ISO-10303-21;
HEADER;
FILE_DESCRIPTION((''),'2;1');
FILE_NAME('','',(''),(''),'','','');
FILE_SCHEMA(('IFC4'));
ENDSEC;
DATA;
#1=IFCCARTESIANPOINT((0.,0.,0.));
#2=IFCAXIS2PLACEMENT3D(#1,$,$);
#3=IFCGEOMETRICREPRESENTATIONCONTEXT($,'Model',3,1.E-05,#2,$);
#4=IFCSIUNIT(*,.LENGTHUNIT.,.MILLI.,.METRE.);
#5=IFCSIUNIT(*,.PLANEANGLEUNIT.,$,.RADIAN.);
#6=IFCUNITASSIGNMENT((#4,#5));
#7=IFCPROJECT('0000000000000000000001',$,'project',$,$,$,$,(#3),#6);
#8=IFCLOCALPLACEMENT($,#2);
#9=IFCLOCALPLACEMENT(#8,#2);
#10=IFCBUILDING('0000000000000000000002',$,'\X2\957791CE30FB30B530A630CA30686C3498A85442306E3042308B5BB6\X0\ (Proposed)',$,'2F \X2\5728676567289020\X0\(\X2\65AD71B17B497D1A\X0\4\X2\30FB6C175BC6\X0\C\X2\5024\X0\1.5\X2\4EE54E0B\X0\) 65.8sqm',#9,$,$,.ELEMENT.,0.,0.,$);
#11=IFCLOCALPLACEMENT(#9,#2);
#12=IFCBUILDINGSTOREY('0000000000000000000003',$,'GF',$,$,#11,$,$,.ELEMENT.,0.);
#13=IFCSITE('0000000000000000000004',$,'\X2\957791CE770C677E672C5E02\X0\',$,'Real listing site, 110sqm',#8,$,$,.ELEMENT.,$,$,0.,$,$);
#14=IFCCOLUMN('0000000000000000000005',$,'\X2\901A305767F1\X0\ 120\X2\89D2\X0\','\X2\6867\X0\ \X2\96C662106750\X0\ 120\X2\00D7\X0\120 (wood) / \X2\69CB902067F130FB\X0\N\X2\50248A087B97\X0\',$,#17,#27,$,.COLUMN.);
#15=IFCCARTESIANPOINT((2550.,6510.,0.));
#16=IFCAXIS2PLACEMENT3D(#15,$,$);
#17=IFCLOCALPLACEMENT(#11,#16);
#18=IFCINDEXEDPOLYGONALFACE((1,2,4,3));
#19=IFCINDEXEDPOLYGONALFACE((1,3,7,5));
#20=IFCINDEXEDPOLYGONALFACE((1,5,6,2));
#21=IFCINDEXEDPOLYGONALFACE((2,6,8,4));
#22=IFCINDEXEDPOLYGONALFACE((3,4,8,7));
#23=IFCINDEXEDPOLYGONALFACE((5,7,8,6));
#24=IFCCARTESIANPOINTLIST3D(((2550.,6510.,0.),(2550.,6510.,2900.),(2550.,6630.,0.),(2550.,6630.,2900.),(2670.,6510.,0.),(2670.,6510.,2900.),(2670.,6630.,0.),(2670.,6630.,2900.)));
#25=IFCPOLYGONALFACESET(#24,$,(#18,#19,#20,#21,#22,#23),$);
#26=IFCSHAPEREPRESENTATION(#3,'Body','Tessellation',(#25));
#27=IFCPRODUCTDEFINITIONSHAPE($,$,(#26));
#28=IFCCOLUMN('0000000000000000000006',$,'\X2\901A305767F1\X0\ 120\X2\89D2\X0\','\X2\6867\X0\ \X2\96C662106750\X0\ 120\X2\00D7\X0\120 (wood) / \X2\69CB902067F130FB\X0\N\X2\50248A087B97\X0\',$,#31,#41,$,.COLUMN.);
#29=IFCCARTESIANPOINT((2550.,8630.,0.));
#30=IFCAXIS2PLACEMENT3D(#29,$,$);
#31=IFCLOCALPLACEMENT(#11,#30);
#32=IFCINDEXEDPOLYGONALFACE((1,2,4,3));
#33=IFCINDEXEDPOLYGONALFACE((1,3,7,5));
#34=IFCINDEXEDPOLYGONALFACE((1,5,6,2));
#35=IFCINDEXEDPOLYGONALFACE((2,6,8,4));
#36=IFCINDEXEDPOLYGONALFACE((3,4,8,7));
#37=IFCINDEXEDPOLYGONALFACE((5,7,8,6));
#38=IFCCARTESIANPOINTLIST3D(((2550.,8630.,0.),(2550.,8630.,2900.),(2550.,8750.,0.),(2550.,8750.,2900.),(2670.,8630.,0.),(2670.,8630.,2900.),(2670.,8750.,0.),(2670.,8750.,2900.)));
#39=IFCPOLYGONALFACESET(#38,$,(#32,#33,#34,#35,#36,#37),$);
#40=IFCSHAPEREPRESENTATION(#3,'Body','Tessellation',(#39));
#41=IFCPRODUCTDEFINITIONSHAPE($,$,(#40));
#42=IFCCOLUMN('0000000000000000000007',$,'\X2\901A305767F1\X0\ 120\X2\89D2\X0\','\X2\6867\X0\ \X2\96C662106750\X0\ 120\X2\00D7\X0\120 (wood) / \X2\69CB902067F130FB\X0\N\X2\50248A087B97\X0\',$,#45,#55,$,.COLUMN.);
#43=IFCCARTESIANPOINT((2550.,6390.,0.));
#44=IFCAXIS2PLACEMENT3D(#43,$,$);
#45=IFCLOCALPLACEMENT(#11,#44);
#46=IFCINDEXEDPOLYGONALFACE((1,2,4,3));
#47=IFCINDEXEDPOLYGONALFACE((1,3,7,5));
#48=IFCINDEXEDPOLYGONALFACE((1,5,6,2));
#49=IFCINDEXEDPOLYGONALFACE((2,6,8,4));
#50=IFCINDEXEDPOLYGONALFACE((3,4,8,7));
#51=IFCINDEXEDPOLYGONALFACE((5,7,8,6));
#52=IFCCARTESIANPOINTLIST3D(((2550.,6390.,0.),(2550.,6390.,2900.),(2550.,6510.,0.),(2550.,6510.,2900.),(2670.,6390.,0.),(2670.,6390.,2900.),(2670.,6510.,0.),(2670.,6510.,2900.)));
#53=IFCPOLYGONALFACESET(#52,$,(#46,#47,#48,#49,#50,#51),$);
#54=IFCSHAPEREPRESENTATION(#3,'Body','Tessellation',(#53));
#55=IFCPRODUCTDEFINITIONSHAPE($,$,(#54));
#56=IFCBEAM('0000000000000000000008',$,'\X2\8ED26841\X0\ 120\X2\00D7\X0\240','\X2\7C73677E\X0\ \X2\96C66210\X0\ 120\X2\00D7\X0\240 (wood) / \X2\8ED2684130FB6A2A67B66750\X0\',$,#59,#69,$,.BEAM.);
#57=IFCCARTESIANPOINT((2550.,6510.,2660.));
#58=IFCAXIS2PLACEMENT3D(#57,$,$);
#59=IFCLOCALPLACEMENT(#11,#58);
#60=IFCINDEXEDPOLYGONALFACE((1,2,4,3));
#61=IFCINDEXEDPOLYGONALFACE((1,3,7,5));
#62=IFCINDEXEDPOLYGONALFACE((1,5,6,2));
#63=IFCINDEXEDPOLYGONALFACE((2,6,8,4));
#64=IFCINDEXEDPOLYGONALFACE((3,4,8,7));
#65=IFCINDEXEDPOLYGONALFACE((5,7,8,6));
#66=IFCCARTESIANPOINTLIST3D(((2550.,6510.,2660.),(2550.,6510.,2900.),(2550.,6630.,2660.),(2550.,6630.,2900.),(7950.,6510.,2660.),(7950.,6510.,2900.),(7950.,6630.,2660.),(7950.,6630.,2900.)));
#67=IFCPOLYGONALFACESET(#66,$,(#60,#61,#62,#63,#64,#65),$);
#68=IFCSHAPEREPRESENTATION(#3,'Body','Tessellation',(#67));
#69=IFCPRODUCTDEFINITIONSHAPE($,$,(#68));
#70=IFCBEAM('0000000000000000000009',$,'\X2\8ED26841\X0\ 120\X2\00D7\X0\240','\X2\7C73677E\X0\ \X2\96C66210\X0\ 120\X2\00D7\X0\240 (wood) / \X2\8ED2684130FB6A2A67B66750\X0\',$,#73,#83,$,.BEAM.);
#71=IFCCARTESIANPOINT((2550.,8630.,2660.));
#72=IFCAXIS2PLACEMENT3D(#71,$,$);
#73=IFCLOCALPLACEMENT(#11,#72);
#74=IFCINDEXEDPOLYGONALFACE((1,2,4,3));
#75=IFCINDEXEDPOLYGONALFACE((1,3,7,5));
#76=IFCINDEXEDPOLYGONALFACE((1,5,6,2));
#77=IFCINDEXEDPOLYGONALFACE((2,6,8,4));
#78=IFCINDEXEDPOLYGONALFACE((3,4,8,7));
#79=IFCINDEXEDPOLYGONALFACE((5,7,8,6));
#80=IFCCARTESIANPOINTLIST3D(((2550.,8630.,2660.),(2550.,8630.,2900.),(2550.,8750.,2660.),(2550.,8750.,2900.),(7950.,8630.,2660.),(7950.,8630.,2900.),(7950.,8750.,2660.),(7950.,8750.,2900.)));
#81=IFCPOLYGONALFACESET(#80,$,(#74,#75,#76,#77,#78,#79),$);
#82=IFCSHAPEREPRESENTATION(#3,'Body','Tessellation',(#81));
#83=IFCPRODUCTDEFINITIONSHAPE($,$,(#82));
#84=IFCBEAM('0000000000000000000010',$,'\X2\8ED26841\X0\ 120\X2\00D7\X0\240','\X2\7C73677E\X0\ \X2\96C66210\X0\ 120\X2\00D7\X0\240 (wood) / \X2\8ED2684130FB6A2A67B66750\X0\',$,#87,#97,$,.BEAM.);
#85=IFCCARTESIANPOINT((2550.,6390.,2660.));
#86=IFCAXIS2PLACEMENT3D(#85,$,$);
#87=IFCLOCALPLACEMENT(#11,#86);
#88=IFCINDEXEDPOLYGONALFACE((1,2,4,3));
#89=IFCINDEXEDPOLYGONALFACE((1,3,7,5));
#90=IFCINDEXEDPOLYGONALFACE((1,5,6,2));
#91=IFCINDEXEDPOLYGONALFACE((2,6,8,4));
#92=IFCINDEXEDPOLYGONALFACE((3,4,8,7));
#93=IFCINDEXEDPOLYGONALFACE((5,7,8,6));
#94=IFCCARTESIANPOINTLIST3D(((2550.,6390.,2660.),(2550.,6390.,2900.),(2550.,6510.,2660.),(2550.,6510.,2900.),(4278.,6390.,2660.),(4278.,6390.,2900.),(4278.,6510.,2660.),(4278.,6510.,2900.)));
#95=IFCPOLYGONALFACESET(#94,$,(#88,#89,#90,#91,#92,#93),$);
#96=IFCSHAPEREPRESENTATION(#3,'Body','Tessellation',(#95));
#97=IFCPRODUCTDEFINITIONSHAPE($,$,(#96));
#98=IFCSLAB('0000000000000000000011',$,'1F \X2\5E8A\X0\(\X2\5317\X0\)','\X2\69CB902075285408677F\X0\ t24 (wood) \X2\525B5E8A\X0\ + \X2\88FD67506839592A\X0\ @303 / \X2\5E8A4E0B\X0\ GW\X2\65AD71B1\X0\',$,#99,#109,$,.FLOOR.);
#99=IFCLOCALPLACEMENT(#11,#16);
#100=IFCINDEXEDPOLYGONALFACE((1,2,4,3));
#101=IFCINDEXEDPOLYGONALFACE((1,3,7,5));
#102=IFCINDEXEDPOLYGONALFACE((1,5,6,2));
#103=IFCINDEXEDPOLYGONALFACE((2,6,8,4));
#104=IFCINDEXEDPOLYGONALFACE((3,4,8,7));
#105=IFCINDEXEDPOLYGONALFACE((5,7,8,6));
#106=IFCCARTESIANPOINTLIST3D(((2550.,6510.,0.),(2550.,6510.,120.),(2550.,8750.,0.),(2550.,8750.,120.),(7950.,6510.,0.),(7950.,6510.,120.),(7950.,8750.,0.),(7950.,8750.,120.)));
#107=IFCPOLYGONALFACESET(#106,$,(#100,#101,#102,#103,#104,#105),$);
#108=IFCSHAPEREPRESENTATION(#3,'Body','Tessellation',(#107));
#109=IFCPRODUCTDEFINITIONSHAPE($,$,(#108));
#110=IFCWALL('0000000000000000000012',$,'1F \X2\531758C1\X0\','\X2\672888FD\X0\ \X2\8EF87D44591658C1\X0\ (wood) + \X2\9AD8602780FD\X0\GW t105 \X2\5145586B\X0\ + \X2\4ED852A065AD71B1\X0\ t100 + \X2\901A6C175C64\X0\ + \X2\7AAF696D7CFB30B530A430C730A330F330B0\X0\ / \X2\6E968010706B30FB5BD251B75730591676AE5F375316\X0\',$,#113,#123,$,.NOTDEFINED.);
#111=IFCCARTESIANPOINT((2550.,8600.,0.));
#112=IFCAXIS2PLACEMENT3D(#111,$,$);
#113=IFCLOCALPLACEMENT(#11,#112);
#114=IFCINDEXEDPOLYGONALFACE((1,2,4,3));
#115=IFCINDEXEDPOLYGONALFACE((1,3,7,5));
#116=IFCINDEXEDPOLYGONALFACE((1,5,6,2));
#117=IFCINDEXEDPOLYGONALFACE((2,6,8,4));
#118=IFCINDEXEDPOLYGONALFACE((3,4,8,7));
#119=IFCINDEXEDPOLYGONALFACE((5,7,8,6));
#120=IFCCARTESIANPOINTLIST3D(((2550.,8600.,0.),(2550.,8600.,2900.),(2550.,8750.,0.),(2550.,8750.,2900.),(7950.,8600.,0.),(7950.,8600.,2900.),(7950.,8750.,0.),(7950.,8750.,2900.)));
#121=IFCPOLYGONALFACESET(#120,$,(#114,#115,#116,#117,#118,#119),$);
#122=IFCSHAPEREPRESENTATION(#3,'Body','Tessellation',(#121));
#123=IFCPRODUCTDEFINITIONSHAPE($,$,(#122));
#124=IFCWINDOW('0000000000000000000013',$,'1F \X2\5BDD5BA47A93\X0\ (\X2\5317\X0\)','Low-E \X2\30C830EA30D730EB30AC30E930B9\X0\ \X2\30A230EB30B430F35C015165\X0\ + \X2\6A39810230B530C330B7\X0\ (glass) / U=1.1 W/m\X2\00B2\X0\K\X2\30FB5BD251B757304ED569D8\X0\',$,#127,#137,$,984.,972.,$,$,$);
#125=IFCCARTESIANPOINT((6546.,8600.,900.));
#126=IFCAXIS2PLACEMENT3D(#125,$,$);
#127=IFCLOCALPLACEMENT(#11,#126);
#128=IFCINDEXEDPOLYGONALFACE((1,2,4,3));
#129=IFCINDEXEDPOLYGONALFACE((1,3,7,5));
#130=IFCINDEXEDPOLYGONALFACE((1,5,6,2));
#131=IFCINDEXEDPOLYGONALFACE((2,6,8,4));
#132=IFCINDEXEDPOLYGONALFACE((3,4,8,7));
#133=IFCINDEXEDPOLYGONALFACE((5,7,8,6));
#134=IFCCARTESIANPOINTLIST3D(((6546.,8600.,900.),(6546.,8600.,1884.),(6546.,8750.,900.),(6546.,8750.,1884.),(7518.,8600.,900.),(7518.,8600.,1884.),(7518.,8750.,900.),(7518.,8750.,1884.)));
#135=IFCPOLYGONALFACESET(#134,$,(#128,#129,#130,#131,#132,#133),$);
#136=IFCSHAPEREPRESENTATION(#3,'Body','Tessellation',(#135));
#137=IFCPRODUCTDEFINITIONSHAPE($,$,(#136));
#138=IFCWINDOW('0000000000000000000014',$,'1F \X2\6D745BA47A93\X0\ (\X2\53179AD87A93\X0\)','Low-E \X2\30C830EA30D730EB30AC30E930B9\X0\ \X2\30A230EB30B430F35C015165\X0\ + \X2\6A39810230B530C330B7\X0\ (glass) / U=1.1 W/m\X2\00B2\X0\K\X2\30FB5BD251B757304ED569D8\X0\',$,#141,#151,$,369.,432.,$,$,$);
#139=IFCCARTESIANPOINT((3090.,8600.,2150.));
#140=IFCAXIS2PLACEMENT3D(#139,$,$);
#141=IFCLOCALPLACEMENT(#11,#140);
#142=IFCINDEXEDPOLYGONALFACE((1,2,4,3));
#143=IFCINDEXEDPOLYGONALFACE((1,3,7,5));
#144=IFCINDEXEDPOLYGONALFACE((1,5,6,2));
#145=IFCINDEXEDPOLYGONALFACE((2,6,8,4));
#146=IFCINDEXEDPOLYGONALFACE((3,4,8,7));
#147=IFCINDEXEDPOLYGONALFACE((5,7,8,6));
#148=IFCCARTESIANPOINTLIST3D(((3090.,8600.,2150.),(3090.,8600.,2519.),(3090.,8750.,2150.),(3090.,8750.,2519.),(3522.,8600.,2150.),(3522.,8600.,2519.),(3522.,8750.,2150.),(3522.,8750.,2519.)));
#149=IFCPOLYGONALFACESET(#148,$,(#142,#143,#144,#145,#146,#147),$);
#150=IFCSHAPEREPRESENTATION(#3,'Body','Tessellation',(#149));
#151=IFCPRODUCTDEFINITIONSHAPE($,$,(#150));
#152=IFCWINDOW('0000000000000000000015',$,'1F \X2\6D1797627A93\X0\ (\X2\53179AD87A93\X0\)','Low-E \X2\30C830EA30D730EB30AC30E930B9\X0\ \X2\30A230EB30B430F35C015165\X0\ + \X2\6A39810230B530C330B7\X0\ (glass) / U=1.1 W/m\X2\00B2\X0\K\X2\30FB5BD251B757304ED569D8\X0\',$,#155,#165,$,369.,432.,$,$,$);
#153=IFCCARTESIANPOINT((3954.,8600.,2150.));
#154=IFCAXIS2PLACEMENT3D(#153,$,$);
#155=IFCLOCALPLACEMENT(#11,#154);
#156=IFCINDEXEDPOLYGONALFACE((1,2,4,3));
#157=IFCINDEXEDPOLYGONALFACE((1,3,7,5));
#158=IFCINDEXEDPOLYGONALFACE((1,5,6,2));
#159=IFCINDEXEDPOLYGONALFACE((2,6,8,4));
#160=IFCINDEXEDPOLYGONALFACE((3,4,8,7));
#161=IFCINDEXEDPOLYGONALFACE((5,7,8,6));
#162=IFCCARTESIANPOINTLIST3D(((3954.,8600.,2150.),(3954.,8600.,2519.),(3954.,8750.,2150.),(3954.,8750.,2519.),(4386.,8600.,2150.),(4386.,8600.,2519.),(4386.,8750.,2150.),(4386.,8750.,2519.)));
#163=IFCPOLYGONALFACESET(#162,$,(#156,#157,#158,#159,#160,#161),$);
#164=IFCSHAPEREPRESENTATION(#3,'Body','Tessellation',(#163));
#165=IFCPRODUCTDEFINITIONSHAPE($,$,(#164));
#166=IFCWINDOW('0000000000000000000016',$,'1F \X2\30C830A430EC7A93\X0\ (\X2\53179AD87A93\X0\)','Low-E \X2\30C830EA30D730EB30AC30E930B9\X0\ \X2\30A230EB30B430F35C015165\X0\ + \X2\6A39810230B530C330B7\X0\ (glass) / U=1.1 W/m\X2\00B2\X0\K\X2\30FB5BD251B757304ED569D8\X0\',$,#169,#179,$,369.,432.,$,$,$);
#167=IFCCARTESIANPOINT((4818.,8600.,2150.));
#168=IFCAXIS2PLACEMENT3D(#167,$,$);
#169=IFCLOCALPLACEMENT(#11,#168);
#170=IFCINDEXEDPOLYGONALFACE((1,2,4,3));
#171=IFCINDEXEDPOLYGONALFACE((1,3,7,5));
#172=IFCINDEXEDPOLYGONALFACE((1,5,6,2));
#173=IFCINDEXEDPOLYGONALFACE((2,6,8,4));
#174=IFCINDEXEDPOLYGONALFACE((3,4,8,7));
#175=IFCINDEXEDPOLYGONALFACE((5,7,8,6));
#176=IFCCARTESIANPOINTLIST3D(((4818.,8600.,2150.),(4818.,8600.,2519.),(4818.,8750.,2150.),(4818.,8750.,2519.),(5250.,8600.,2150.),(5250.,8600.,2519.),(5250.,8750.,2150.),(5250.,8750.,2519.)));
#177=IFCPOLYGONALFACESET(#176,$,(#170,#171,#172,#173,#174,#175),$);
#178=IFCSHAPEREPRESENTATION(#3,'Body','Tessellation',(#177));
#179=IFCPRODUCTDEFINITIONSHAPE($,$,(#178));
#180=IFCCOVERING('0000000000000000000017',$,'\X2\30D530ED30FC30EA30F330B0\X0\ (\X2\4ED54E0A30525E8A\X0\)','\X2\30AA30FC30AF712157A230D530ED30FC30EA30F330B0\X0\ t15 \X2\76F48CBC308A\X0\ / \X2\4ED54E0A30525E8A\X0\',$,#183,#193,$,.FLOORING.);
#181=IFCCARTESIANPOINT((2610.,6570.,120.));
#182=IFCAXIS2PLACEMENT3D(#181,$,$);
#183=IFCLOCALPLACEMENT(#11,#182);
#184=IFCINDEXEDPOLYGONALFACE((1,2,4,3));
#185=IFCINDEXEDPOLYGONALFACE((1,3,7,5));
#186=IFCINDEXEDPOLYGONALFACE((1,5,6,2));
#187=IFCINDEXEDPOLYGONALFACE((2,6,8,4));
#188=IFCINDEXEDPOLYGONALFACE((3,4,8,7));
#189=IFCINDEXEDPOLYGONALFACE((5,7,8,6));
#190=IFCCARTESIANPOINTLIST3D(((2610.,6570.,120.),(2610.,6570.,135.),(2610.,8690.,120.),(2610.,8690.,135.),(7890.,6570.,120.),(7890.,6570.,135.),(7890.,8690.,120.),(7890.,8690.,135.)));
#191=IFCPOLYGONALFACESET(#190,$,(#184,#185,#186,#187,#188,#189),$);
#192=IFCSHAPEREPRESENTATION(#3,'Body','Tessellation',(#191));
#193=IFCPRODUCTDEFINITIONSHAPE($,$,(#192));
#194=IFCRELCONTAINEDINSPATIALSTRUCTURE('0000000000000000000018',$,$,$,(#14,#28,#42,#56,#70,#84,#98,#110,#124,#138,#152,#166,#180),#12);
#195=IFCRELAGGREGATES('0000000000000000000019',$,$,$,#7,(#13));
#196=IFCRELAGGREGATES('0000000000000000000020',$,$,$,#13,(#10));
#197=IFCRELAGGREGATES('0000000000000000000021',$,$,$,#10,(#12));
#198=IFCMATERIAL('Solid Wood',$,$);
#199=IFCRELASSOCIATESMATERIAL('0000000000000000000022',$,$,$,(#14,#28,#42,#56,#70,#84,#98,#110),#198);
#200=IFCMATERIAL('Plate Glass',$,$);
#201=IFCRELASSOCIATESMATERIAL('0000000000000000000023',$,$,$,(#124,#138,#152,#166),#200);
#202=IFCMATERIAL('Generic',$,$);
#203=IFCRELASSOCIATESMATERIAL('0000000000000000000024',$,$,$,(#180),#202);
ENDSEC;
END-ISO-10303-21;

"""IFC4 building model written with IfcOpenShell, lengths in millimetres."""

from ifc_helpers import new_model, si_unit, frame, frame_2d, origin, place, context, project, spatial, rectangle, extrude, material, element, fill, save


model = new_model("IFC4")

# Units and contexts
model_context = context("Model", 3, precision=1e-05, world=origin())
ifc_project = project(units=[si_unit("LENGTHUNIT", "METRE", prefix="MILLI"), si_unit("PLANEANGLEUNIT", "RADIAN")], contexts=[model_context])

# Site, building, storey
site_placement = place(None, origin())
site = spatial("IfcSite", under=ifc_project, at=site_placement, Name="長野県松本市", ObjectType="Real listing site, 110sqm", CompositionType="ELEMENT", RefElevation=0.0)
building_placement = place(site_placement, origin())
building = spatial("IfcBuilding", under=site, at=building_placement, Name="長野・サウナと水風呂のある家 (Proposed)", ObjectType="2F 在来木造(断熱等級4・気密C値1.5以下) 65.8sqm", CompositionType="ELEMENT", ElevationOfRefHeight=0.0, ElevationOfTerrain=0.0)
storey_placement = place(building_placement, origin())
storey = spatial("IfcBuildingStorey", under=building, at=storey_placement, Name="GF", CompositionType="ELEMENT", Elevation=0.0)

# Columns
ifc_material_1 = material(Name="Solid Wood")
column_1_placement = place(storey_placement, frame((2550.0, 6510.0, 0.0)))
element("IfcColumn", 1, at=column_1_placement, inside=storey, material=ifc_material_1, Name="通し柱 120角", Description="桧 集成材 120×120 (wood) / 構造柱・N値計算", PredefinedType="COLUMN", context=model_context, shape_type="SweptSolid", body=[
    extrude(rectangle(XDim=120.0, YDim=120.0, at=frame_2d((60.0, 60.0))), frame((2550.0, 6510.0, 0.0)), (0.0, 0.0, 1.0), 2900.0),
])
column_2_placement = place(storey_placement, frame((2550.0, 8630.0, 0.0)))
element("IfcColumn", 2, at=column_2_placement, inside=storey, material=ifc_material_1, Name="通し柱 120角", Description="桧 集成材 120×120 (wood) / 構造柱・N値計算", PredefinedType="COLUMN", context=model_context, shape_type="SweptSolid", body=[
    extrude(rectangle(XDim=120.0, YDim=120.0, at=frame_2d((60.0, 60.0))), frame((2550.0, 8630.0, 0.0)), (0.0, 0.0, 1.0), 2900.0),
])
column_3_placement = place(storey_placement, frame((2550.0, 6390.0, 0.0)))
element("IfcColumn", 3, at=column_3_placement, inside=storey, material=ifc_material_1, Name="通し柱 120角", Description="桧 集成材 120×120 (wood) / 構造柱・N値計算", PredefinedType="COLUMN", context=model_context, shape_type="SweptSolid", body=[
    extrude(rectangle(XDim=120.0, YDim=120.0, at=frame_2d((60.0, 60.0))), frame((2550.0, 6390.0, 0.0)), (0.0, 0.0, 1.0), 2900.0),
])

# Beams
beam_1_placement = place(storey_placement, frame((2550.0, 6510.0, 2660.0)))
element("IfcBeam", 4, at=beam_1_placement, inside=storey, material=ifc_material_1, Name="軒桁 120×240", Description="米松 集成 120×240 (wood) / 軒桁・横架材", PredefinedType="BEAM", context=model_context, shape_type="SweptSolid", body=[
    extrude(rectangle(XDim=5400.0, YDim=120.0, at=frame_2d((2700.0, 60.0))), frame((2550.0, 6510.0, 2660.0)), (0.0, 0.0, 1.0), 240.0),
])
beam_2_placement = place(storey_placement, frame((2550.0, 8630.0, 2660.0)))
element("IfcBeam", 5, at=beam_2_placement, inside=storey, material=ifc_material_1, Name="軒桁 120×240", Description="米松 集成 120×240 (wood) / 軒桁・横架材", PredefinedType="BEAM", context=model_context, shape_type="SweptSolid", body=[
    extrude(rectangle(XDim=5400.0, YDim=120.0, at=frame_2d((2700.0, 60.0))), frame((2550.0, 8630.0, 2660.0)), (0.0, 0.0, 1.0), 240.0),
])
beam_3_placement = place(storey_placement, frame((2550.0, 6390.0, 2660.0)))
element("IfcBeam", 6, at=beam_3_placement, inside=storey, material=ifc_material_1, Name="軒桁 120×240", Description="米松 集成 120×240 (wood) / 軒桁・横架材", PredefinedType="BEAM", context=model_context, shape_type="SweptSolid", body=[
    extrude(rectangle(XDim=1728.0, YDim=120.0, at=frame_2d((864.0, 60.0))), frame((2550.0, 6390.0, 2660.0)), (0.0, 0.0, 1.0), 240.0),
])

# Slab
slab_placement = place(storey_placement, frame((2550.0, 6510.0, 0.0)))
element("IfcSlab", 7, at=slab_placement, inside=storey, material=ifc_material_1, Name="1F 床(北)", Description="構造用合板 t24 (wood) 剛床 + 製材根太 @303 / 床下 GW断熱", PredefinedType="FLOOR", context=model_context, shape_type="SweptSolid", body=[
    extrude(rectangle(XDim=5400.0, YDim=2240.0, at=frame_2d((2700.0, 1120.0))), frame((2550.0, 6510.0, 0.0)), (0.0, 0.0, 1.0), 120.0),
])

# Wall, openings, windows
wall_1_placement = place(storey_placement, frame((2550.0, 8600.0, 0.0)))
wall_1 = element("IfcWall", 8, at=wall_1_placement, inside=storey, material=ifc_material_1, Name="1F 北壁", Description="木製 軸組外壁 (wood) + 高性能GW t105 充填 + 付加断熱 t100 + 通気層 + 窯業系サイディング / 準耐火・寒冷地外皮強化", PredefinedType="NOTDEFINED", context=model_context, shape_type="SweptSolid", body=[
    extrude(rectangle(XDim=5400.0, YDim=150.0, at=frame_2d((2700.0, 75.0))), frame((2550.0, 8600.0, 0.0)), (0.0, 0.0, 1.0), 2900.0),
])
opening_1_placement = place(storey_placement, frame((6546.0, 8600.0, 900.0)))
opening_1 = element("IfcOpeningElement", 9, at=opening_1_placement, cuts=wall_1, PredefinedType="NOTDEFINED", context=model_context, shape_type="SweptSolid", body=[
    extrude(rectangle(XDim=972.0, YDim=150.0, at=frame_2d((486.0, 75.0))), frame((6546.0, 8600.0, 900.0)), (0.0, 0.0, 1.0), 984.0),
])
opening_2_placement = place(storey_placement, frame((3090.0, 8600.0, 2150.0)))
opening_2 = element("IfcOpeningElement", 10, at=opening_2_placement, cuts=wall_1, PredefinedType="NOTDEFINED", context=model_context, shape_type="SweptSolid", body=[
    extrude(rectangle(XDim=432.0, YDim=150.0, at=frame_2d((216.0, 75.0))), frame((3090.0, 8600.0, 2150.0)), (0.0, 0.0, 1.0), 369.0),
])
opening_3_placement = place(storey_placement, frame((3954.0, 8600.0, 2150.0)))
opening_3 = element("IfcOpeningElement", 11, at=opening_3_placement, cuts=wall_1, PredefinedType="NOTDEFINED", context=model_context, shape_type="SweptSolid", body=[
    extrude(rectangle(XDim=432.0, YDim=150.0, at=frame_2d((216.0, 75.0))), frame((3954.0, 8600.0, 2150.0)), (0.0, 0.0, 1.0), 369.0),
])
opening_4_placement = place(storey_placement, frame((4818.0, 8600.0, 2150.0)))
opening_4 = element("IfcOpeningElement", 12, at=opening_4_placement, cuts=wall_1, PredefinedType="NOTDEFINED", context=model_context, shape_type="SweptSolid", body=[
    extrude(rectangle(XDim=432.0, YDim=150.0, at=frame_2d((216.0, 75.0))), frame((4818.0, 8600.0, 2150.0)), (0.0, 0.0, 1.0), 369.0),
])
ifc_material_2 = material(Name="Plate Glass")
window_1_placement = place(storey_placement, frame((6546.0, 8600.0, 900.0)))
window_1 = element("IfcWindow", 13, at=window_1_placement, inside=storey, material=ifc_material_2, Name="1F 寝室窓 (北)", Description="Low-E トリプルガラス アルゴン封入 + 樹脂サッシ (glass) / U=1.1 W/m²K・寒冷地仕様", OverallHeight=984.0, OverallWidth=972.0, context=model_context, shape_type="SweptSolid", body=[
    extrude(rectangle(XDim=972.0, YDim=150.0, at=frame_2d((486.0, 75.0))), frame((6546.0, 8600.0, 900.0)), (0.0, 0.0, 1.0), 984.0),
])
fill(opening_1, window_1)
window_2_placement = place(storey_placement, frame((3090.0, 8600.0, 2150.0)))
window_2 = element("IfcWindow", 14, at=window_2_placement, inside=storey, material=ifc_material_2, Name="1F 浴室窓 (北高窓)", Description="Low-E トリプルガラス アルゴン封入 + 樹脂サッシ (glass) / U=1.1 W/m²K・寒冷地仕様", OverallHeight=369.0, OverallWidth=432.0, context=model_context, shape_type="SweptSolid", body=[
    extrude(rectangle(XDim=432.0, YDim=150.0, at=frame_2d((216.0, 75.0))), frame((3090.0, 8600.0, 2150.0)), (0.0, 0.0, 1.0), 369.0),
])
fill(opening_2, window_2)
window_3_placement = place(storey_placement, frame((3954.0, 8600.0, 2150.0)))
window_3 = element("IfcWindow", 15, at=window_3_placement, inside=storey, material=ifc_material_2, Name="1F 洗面窓 (北高窓)", Description="Low-E トリプルガラス アルゴン封入 + 樹脂サッシ (glass) / U=1.1 W/m²K・寒冷地仕様", OverallHeight=369.0, OverallWidth=432.0, context=model_context, shape_type="SweptSolid", body=[
    extrude(rectangle(XDim=432.0, YDim=150.0, at=frame_2d((216.0, 75.0))), frame((3954.0, 8600.0, 2150.0)), (0.0, 0.0, 1.0), 369.0),
])
fill(opening_3, window_3)
window_4_placement = place(storey_placement, frame((4818.0, 8600.0, 2150.0)))
window_4 = element("IfcWindow", 16, at=window_4_placement, inside=storey, material=ifc_material_2, Name="1F トイレ窓 (北高窓)", Description="Low-E トリプルガラス アルゴン封入 + 樹脂サッシ (glass) / U=1.1 W/m²K・寒冷地仕様", OverallHeight=369.0, OverallWidth=432.0, context=model_context, shape_type="SweptSolid", body=[
    extrude(rectangle(XDim=432.0, YDim=150.0, at=frame_2d((216.0, 75.0))), frame((4818.0, 8600.0, 2150.0)), (0.0, 0.0, 1.0), 369.0),
])
fill(opening_4, window_4)

# Covering
ifc_material_3 = material(Name="Generic")
covering_1_placement = place(storey_placement, frame((2610.0, 6570.0, 120.0)))
element("IfcCovering", 17, at=covering_1_placement, inside=storey, material=ifc_material_3, Name="フローリング (仕上げ床)", Description="オーク無垢フローリング t15 直貼り / 仕上げ床", PredefinedType="FLOORING", context=model_context, shape_type="SweptSolid", body=[
    extrude(rectangle(XDim=5280.0, YDim=2120.0, at=frame_2d((2640.0, 1060.0))), frame((2610.0, 6570.0, 120.0)), (0.0, 0.0, 1.0), 15.0),
])

save(model, "model.ifc")
